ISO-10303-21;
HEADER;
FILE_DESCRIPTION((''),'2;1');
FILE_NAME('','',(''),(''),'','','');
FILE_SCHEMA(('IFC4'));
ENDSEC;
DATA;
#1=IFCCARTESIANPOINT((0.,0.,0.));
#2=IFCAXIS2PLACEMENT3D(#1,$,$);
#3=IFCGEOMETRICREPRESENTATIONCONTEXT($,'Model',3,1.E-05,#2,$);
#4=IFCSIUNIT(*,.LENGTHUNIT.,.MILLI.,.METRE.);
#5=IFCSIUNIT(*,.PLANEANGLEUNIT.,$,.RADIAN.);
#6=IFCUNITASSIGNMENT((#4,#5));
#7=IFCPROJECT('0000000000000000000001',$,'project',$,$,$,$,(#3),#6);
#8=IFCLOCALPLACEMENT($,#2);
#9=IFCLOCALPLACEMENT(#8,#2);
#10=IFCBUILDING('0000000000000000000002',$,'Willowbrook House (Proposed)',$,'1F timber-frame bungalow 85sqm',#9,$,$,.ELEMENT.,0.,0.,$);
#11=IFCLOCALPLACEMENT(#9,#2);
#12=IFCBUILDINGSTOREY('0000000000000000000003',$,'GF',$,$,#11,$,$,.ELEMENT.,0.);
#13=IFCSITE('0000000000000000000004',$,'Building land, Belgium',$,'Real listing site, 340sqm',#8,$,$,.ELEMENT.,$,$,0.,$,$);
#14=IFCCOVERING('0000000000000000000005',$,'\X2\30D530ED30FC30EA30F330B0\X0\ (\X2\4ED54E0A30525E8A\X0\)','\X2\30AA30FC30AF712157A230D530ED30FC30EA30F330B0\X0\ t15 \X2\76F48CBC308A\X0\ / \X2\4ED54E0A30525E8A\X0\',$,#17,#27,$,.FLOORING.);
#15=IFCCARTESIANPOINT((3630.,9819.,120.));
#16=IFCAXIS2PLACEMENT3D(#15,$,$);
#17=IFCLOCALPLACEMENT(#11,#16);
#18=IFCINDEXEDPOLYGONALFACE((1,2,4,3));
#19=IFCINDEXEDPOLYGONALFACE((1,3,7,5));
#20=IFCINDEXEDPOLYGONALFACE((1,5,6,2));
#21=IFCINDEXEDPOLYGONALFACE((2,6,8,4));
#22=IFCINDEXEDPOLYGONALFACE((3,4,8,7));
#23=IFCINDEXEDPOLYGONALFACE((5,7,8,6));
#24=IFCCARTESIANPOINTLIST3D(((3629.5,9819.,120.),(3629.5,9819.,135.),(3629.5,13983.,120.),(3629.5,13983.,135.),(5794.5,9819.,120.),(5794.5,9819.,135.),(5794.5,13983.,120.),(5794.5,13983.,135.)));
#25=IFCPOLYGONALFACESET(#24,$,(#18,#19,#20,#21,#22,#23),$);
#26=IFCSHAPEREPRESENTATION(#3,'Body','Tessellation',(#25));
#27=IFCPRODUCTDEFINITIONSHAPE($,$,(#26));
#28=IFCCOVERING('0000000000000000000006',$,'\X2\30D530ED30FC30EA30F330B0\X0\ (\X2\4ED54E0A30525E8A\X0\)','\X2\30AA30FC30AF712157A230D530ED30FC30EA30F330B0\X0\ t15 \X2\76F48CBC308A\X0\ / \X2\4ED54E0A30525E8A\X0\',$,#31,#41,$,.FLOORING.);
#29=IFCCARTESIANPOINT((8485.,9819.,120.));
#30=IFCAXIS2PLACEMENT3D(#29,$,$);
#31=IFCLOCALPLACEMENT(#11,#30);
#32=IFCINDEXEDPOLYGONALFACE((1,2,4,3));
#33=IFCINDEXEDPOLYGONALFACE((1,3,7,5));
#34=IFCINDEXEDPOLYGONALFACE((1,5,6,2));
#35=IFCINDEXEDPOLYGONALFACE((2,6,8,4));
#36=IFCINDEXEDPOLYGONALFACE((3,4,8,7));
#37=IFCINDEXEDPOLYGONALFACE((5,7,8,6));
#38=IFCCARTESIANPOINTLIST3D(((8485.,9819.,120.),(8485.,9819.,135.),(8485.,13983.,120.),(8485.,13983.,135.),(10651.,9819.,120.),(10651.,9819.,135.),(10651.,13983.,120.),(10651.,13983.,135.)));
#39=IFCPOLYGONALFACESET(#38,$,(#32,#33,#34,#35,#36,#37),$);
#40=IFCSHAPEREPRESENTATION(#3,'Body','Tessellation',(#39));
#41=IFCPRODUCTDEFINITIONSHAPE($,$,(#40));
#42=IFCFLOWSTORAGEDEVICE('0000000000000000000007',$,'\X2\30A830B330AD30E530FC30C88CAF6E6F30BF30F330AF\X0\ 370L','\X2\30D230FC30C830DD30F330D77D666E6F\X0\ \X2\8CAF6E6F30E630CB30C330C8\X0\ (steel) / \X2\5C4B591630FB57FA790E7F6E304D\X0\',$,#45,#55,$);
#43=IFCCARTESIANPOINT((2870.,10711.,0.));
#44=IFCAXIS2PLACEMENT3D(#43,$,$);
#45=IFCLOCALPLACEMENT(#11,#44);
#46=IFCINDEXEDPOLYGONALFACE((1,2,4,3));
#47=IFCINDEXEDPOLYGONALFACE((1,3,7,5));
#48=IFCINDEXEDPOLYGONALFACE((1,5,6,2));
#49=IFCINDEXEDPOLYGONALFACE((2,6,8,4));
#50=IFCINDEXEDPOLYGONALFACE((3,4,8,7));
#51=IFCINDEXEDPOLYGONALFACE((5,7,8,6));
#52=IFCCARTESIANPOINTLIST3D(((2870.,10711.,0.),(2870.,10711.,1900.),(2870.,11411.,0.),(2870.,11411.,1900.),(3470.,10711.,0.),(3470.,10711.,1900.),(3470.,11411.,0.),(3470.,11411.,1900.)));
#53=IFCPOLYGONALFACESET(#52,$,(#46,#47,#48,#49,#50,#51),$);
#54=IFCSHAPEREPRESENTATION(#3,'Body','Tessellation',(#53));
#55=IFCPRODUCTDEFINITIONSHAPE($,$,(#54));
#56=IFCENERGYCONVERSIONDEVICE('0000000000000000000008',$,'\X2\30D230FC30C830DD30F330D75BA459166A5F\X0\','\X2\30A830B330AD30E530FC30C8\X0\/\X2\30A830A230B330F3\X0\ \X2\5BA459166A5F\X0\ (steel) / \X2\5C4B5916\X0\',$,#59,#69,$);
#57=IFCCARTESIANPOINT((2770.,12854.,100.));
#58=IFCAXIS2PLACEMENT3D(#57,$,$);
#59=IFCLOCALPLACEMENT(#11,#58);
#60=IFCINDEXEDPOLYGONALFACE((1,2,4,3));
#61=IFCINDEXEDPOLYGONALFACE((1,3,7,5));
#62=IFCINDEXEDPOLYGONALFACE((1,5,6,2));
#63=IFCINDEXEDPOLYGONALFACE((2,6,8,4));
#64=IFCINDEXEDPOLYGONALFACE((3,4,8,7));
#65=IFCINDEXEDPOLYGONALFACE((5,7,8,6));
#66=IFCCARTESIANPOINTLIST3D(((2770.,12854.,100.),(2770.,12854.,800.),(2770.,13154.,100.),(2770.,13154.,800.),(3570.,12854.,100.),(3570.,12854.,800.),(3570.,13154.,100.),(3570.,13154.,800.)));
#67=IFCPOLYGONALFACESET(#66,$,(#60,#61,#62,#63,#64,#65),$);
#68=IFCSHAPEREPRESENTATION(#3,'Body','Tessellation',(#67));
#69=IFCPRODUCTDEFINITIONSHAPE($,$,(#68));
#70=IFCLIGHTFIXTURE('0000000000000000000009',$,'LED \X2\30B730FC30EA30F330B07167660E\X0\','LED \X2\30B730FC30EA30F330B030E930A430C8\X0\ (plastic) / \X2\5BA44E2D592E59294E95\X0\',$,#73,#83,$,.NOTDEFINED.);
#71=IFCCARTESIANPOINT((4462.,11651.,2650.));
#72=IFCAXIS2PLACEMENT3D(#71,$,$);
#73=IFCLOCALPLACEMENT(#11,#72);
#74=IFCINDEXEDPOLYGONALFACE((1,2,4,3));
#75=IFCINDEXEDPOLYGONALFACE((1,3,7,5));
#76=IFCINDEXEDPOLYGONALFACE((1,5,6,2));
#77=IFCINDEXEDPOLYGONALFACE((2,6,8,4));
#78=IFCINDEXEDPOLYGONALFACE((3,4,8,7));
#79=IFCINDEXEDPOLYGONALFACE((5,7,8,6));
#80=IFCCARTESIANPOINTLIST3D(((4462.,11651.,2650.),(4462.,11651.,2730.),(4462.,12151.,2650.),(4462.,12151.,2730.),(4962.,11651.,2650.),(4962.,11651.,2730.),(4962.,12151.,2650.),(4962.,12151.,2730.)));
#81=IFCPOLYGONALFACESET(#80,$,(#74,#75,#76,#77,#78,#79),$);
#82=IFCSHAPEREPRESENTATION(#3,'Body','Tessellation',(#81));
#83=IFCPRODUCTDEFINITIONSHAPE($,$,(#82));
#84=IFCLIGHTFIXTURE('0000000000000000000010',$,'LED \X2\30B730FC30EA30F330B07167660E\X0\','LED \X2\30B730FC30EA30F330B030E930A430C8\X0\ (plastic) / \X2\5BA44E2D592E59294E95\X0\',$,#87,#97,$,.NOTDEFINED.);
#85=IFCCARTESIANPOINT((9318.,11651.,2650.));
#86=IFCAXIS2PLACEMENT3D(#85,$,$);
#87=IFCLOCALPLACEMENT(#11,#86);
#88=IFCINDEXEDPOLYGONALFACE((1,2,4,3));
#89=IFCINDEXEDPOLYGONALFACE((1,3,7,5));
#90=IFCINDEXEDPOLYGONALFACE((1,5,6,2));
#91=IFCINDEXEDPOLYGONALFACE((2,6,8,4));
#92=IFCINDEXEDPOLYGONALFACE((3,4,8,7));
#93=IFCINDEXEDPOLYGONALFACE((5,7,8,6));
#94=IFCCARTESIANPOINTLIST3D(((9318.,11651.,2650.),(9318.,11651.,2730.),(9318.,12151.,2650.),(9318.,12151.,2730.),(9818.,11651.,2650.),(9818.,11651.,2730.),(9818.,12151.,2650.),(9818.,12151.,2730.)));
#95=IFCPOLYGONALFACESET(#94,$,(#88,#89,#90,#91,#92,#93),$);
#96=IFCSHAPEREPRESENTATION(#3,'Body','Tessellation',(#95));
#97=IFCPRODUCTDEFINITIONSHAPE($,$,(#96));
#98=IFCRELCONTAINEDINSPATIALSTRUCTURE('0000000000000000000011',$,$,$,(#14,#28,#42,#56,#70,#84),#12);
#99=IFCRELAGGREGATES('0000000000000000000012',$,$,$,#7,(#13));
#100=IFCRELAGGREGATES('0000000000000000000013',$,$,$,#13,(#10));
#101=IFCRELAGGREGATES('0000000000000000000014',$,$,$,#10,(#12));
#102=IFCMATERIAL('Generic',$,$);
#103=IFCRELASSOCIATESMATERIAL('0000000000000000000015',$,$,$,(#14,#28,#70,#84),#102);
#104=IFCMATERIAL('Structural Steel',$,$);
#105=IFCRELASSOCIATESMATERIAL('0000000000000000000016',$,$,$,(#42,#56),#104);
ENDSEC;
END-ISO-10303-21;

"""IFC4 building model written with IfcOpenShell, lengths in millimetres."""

from ifc_helpers import new_model, si_unit, frame, frame_2d, origin, place, context, project, spatial, rectangle, extrude, material, element, save


model = new_model("IFC4")

# Units and contexts
model_context = context("Model", 3, precision=1e-05, world=origin())
ifc_project = project(units=[si_unit("LENGTHUNIT", "METRE", prefix="MILLI"), si_unit("PLANEANGLEUNIT", "RADIAN")], contexts=[model_context])

# Site, building, storey
site_placement = place(None, origin())
site = spatial("IfcSite", under=ifc_project, at=site_placement, Name="Building land, Belgium", ObjectType="Real listing site, 340sqm", CompositionType="ELEMENT", RefElevation=0.0)
building_placement = place(site_placement, origin())
building = spatial("IfcBuilding", under=site, at=building_placement, Name="Willowbrook House (Proposed)", ObjectType="1F timber-frame bungalow 85sqm", CompositionType="ELEMENT", ElevationOfRefHeight=0.0, ElevationOfTerrain=0.0)
storey_placement = place(building_placement, origin())
storey = spatial("IfcBuildingStorey", under=building, at=storey_placement, Name="GF", CompositionType="ELEMENT", Elevation=0.0)

# Shared definitions
ifc_material_1 = material(Name="Structural Steel")

# Coverings
ifc_material_2 = material(Name="Generic")
covering_1_placement = place(storey_placement, frame((3630.0, 9819.0, 120.0)))
element("IfcCovering", 1, at=covering_1_placement, inside=storey, material=ifc_material_2, Name="フローリング (仕上げ床)", Description="オーク無垢フローリング t15 直貼り / 仕上げ床", PredefinedType="FLOORING", context=model_context, shape_type="SweptSolid", body=[
    extrude(rectangle(XDim=2165.0, YDim=4164.0, at=frame_2d((1082.0, 2082.0))), frame((3630.0, 9819.0, 120.0)), (0.0, 0.0, 1.0), 15.0),
])
covering_2_placement = place(storey_placement, frame((8485.0, 9819.0, 120.0)))
element("IfcCovering", 2, at=covering_2_placement, inside=storey, material=ifc_material_2, Name="フローリング (仕上げ床)", Description="オーク無垢フローリング t15 直貼り / 仕上げ床", PredefinedType="FLOORING", context=model_context, shape_type="SweptSolid", body=[
    extrude(rectangle(XDim=2166.0, YDim=4164.0, at=frame_2d((1083.0, 2082.0))), frame((8485.0, 9819.0, 120.0)), (0.0, 0.0, 1.0), 15.0),
])

# Flow storage device
flow_storage_device_placement = place(storey_placement, frame((2870.0, 10711.0, 0.0)))
element("IfcFlowStorageDevice", 3, at=flow_storage_device_placement, inside=storey, material=ifc_material_1, Name="エコキュート貯湯タンク 370L", Description="ヒートポンプ給湯 貯湯ユニット (steel) / 屋外・基礎置き", context=model_context, shape_type="SweptSolid", body=[
    extrude(rectangle(XDim=600.0, YDim=700.0, at=frame_2d((300.0, 350.0))), frame((2870.0, 10711.0, 0.0)), (0.0, 0.0, 1.0), 1900.0),
])

# Energy conversion device
energy_conversion_device_placement = place(storey_placement, frame((2770.0, 12854.0, 100.0)))
element("IfcEnergyConversionDevice", 4, at=energy_conversion_device_placement, inside=storey, material=ifc_material_1, Name="ヒートポンプ室外機", Description="エコキュート/エアコン 室外機 (steel) / 屋外", context=model_context, shape_type="SweptSolid", body=[
    extrude(rectangle(XDim=800.0, YDim=300.0, at=frame_2d((400.0, 150.0))), frame((2770.0, 12854.0, 100.0)), (0.0, 0.0, 1.0), 700.0),
])

# Light fixtures
light_fixture_1_placement = place(storey_placement, frame((4462.0, 11651.0, 2650.0)))
element("IfcLightFixture", 5, at=light_fixture_1_placement, inside=storey, material=ifc_material_2, Name="LED シーリング照明", Description="LED シーリングライト (plastic) / 室中央天井", PredefinedType="NOTDEFINED", context=model_context, shape_type="SweptSolid", body=[
    extrude(rectangle(XDim=500.0, YDim=500.0, at=frame_2d((250.0, 250.0))), frame((4462.0, 11651.0, 2650.0)), (0.0, 0.0, 1.0), 80.0),
])
light_fixture_2_placement = place(storey_placement, frame((9318.0, 11651.0, 2650.0)))
element("IfcLightFixture", 6, at=light_fixture_2_placement, inside=storey, material=ifc_material_2, Name="LED シーリング照明", Description="LED シーリングライト (plastic) / 室中央天井", PredefinedType="NOTDEFINED", context=model_context, shape_type="SweptSolid", body=[
    extrude(rectangle(XDim=500.0, YDim=500.0, at=frame_2d((250.0, 250.0))), frame((9318.0, 11651.0, 2650.0)), (0.0, 0.0, 1.0), 80.0),
])

save(model, "model.ifc")
